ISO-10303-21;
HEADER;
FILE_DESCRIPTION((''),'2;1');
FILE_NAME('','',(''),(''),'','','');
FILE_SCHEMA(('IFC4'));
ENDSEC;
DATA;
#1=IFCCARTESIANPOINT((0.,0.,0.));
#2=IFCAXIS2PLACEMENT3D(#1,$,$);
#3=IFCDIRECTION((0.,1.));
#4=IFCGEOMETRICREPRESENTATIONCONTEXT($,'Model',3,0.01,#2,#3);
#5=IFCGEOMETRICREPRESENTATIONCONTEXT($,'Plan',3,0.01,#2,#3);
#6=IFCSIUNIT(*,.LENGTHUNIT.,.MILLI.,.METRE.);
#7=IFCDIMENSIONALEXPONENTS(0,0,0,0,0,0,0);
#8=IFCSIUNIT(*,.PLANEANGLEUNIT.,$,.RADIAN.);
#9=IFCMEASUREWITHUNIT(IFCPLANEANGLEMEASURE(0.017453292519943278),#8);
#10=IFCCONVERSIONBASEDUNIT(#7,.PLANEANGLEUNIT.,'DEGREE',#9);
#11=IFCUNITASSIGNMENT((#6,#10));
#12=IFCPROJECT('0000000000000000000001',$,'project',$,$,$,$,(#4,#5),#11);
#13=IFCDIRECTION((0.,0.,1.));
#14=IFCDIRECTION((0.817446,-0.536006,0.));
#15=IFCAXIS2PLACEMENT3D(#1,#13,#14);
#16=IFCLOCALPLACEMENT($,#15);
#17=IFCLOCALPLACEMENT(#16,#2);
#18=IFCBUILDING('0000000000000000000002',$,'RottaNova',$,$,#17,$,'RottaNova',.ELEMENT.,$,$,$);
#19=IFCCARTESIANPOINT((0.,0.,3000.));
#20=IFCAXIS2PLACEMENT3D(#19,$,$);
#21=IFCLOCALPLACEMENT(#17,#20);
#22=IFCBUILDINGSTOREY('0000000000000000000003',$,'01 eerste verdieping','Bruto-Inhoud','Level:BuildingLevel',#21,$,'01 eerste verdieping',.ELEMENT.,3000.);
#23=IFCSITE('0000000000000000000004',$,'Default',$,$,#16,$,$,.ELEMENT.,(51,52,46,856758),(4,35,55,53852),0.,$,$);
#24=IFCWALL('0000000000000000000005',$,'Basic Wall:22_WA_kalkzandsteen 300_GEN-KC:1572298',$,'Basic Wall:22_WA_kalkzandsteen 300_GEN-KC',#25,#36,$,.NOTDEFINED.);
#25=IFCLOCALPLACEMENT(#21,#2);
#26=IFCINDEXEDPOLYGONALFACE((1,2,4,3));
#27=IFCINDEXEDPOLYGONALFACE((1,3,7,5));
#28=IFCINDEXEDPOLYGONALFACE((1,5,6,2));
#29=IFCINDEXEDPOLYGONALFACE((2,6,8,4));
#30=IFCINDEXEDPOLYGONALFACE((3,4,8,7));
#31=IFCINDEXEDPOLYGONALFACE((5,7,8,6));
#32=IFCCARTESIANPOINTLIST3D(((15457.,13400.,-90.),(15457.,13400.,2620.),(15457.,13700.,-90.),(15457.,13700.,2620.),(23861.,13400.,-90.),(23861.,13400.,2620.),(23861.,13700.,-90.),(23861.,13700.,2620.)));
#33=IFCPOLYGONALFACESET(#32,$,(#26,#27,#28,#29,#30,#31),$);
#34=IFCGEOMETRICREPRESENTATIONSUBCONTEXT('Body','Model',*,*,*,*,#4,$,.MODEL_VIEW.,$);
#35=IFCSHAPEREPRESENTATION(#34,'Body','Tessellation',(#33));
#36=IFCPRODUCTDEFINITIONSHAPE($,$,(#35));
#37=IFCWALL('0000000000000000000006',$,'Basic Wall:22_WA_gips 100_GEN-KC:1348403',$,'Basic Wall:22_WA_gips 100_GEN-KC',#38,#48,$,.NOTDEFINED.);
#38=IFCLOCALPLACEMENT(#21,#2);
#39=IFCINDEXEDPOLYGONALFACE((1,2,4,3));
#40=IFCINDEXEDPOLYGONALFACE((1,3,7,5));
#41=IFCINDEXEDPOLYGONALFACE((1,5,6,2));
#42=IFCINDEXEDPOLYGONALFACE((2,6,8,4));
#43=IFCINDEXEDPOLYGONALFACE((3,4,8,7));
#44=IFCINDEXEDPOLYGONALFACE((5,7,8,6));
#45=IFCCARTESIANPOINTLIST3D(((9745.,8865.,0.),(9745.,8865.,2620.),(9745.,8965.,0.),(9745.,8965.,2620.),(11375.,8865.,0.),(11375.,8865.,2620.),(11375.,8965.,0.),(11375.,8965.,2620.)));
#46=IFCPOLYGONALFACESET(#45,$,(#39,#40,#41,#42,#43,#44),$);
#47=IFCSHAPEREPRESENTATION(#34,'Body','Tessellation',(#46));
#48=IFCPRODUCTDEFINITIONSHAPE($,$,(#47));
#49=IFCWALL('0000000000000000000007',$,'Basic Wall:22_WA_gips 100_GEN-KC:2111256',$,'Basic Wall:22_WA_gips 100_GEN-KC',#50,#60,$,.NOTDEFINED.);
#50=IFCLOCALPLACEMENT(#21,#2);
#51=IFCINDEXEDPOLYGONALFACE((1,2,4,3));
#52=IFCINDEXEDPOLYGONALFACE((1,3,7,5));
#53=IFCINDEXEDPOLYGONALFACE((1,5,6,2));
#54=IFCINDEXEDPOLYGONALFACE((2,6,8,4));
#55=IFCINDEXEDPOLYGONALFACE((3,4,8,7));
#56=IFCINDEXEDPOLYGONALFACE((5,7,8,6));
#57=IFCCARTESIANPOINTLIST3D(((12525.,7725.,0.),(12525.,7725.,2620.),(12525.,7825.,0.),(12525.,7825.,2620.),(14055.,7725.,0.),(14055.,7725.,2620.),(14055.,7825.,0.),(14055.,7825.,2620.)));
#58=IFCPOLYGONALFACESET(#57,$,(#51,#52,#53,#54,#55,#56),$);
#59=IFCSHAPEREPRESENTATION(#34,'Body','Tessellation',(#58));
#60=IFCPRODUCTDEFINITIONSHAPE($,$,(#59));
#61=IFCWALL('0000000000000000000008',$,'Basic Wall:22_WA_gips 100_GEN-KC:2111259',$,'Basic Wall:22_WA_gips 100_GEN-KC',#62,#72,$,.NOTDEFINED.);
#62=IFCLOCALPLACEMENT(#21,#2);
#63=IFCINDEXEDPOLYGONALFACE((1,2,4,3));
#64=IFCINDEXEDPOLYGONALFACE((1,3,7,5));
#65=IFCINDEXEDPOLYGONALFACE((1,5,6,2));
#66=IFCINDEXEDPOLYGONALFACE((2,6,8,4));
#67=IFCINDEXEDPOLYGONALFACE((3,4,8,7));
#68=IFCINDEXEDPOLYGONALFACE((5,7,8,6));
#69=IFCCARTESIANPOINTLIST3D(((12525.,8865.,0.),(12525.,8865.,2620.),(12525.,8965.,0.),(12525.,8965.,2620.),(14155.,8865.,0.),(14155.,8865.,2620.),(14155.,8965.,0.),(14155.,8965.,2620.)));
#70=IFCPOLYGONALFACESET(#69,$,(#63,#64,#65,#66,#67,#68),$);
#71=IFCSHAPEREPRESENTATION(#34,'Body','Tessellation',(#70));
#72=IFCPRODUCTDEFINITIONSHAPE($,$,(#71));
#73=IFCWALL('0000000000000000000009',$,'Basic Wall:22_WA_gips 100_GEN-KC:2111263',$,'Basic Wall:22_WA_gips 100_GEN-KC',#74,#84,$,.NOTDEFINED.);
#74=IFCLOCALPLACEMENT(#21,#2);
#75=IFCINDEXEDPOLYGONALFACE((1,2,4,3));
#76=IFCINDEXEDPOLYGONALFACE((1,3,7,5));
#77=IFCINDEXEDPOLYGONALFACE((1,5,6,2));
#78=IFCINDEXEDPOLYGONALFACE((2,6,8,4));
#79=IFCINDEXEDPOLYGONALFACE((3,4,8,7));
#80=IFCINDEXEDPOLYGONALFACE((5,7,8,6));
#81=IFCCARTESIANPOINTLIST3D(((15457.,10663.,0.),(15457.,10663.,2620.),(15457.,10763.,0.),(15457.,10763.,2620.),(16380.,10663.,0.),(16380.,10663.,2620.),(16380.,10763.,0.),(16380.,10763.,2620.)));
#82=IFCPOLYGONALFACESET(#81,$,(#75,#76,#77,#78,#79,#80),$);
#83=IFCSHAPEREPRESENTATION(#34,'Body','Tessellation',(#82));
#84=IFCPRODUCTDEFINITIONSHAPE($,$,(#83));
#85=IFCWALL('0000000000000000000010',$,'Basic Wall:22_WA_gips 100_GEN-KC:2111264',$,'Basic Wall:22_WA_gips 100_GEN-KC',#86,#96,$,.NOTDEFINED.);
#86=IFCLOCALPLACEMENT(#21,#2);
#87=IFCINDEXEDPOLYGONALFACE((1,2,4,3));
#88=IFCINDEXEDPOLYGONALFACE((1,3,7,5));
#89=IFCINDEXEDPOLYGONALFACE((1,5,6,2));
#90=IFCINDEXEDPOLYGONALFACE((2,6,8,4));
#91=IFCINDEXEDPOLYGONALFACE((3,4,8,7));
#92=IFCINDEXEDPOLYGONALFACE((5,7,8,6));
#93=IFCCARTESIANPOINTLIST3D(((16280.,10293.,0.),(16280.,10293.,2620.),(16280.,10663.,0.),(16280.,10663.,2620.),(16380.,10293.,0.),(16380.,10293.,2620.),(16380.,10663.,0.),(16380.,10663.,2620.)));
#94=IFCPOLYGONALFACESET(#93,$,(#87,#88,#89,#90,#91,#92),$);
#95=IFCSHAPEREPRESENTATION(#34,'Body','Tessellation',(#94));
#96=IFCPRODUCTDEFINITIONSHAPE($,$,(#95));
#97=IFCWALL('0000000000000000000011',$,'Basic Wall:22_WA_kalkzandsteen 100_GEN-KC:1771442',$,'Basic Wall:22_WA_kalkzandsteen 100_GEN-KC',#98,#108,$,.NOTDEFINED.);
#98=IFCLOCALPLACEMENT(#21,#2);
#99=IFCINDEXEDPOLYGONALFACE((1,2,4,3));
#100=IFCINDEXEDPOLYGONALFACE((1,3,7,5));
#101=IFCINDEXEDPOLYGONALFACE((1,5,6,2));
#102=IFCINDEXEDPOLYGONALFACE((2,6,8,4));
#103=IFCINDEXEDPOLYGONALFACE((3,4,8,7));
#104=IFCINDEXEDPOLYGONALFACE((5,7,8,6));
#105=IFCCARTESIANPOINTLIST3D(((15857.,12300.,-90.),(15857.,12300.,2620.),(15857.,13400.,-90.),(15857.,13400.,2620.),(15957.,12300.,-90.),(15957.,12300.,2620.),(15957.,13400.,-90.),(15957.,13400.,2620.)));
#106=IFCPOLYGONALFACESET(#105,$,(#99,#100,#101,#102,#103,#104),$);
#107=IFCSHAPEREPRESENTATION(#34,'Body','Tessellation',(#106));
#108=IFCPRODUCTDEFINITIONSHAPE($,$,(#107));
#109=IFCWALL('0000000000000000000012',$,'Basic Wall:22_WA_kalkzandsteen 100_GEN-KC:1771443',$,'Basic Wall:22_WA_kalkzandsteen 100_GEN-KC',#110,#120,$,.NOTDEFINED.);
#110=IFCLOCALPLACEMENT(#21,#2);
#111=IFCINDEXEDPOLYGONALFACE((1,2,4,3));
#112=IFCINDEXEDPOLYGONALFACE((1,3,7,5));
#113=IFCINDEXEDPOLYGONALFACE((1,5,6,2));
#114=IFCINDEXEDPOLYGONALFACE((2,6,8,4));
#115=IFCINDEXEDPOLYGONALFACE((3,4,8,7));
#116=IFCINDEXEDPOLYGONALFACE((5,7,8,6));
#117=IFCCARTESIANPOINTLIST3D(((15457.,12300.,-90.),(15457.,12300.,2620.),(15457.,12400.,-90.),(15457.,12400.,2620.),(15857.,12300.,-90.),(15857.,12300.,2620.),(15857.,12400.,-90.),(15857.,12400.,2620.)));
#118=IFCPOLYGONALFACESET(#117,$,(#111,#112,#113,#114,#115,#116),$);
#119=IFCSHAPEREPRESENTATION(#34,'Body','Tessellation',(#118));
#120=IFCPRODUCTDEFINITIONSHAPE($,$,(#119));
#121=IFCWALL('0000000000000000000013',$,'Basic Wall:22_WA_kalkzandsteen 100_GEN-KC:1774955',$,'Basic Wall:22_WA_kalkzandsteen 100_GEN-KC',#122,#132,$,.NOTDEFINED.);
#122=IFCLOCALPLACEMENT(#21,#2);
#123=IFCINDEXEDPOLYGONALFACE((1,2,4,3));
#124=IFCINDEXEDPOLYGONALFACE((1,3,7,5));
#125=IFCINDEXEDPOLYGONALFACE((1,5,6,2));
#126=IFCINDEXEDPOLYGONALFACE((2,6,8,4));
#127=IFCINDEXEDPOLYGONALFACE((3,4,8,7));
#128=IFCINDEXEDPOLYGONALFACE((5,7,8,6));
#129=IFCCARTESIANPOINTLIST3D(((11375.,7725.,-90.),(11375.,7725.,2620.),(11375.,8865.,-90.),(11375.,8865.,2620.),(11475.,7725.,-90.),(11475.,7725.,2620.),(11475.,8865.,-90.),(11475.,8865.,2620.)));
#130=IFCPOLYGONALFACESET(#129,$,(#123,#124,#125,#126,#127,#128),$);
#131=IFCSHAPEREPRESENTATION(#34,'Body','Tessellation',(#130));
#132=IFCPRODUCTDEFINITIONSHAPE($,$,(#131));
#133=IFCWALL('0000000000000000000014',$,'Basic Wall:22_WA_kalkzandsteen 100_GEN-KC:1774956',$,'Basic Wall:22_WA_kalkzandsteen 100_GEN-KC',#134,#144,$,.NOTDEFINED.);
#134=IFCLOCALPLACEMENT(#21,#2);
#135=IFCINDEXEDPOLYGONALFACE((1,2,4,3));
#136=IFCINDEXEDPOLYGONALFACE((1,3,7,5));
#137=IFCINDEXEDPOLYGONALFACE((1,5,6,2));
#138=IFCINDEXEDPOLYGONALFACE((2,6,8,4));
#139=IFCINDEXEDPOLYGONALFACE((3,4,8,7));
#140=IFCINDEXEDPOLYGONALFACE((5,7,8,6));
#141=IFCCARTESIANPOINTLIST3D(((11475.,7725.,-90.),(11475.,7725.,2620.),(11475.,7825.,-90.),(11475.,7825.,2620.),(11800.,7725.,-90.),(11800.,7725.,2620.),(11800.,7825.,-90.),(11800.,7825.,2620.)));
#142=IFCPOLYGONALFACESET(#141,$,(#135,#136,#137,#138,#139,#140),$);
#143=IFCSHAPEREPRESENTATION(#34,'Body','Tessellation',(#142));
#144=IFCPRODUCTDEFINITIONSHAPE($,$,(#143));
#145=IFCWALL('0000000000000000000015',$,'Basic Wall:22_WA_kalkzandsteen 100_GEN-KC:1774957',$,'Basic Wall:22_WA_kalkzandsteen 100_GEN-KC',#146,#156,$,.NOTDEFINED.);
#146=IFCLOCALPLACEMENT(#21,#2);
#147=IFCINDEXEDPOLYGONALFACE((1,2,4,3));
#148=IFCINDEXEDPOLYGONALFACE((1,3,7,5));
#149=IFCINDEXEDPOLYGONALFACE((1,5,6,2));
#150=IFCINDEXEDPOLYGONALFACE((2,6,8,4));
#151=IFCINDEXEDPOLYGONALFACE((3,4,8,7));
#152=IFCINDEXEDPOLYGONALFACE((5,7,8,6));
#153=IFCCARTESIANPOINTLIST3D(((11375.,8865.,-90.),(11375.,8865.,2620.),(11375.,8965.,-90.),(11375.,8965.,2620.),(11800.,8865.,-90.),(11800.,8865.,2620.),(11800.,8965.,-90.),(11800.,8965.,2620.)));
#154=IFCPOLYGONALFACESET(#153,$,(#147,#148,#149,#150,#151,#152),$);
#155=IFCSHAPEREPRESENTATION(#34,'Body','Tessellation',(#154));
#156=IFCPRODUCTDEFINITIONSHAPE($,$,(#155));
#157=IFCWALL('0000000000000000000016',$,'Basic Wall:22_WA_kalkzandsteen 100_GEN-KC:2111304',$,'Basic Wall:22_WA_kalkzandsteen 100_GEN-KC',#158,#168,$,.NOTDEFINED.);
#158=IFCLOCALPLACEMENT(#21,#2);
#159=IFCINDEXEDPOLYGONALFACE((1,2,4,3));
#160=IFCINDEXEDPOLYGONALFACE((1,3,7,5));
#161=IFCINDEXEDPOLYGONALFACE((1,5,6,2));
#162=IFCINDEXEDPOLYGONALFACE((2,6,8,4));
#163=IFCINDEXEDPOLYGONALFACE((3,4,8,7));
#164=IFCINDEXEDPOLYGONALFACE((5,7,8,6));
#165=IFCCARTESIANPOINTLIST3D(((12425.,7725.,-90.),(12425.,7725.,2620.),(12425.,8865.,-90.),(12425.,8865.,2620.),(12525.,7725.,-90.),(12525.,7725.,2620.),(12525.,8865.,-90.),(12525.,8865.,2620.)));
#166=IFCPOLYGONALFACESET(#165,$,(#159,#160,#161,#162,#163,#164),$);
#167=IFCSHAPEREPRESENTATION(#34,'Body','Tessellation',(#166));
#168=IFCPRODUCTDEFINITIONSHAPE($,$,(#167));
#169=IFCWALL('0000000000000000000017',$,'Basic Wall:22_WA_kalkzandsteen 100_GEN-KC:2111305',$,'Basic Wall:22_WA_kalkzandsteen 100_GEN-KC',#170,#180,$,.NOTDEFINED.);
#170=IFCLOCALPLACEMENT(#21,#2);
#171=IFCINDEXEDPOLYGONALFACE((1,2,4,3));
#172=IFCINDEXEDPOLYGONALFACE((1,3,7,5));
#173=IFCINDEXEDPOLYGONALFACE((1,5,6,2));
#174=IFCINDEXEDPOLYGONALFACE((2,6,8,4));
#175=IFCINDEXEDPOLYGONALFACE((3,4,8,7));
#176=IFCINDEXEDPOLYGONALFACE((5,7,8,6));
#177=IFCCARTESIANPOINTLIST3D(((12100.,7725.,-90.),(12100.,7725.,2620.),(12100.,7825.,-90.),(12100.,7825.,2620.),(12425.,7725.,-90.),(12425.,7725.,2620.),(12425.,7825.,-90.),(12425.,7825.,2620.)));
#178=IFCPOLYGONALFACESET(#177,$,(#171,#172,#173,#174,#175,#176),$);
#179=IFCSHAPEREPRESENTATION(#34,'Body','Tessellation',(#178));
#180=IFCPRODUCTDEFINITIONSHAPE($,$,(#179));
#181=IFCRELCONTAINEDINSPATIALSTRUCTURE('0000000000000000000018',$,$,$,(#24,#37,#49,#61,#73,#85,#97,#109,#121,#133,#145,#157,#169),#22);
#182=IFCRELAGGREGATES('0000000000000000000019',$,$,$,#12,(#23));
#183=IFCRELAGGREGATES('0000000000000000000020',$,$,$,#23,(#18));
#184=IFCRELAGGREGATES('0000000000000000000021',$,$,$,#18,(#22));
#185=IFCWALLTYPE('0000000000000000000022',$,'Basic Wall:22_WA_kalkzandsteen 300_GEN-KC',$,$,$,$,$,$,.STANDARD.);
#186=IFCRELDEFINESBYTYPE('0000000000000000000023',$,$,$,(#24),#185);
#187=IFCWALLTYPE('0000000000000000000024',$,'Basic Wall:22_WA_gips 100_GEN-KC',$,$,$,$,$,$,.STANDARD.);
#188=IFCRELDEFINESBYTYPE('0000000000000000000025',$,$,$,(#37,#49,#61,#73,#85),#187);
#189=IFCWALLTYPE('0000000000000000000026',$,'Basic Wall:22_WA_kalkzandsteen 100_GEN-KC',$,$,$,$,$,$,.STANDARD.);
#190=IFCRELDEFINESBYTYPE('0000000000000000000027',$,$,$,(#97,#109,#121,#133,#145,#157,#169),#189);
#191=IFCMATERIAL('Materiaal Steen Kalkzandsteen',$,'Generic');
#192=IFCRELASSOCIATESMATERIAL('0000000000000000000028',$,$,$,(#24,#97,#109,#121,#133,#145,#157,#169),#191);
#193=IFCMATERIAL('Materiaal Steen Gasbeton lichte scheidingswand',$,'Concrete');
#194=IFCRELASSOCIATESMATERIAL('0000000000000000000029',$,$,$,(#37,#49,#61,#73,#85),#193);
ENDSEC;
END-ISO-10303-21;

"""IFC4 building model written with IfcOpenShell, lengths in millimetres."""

from ifc_helpers import new_model, entity, si_unit, converted_unit, direction, frame, origin, place, context, subcontext, project, spatial, indexed_curve, outline, extrude, material, type_object, element, save


model = new_model("IFC4")

# Units and contexts
model_context = context("Model", 3, precision=0.01, world=origin(), true_north=direction((0.0, 1.0)))
plan_context = context("Plan", 3, precision=0.01, world=origin(), true_north=direction((0.0, 1.0)))
body_context = subcontext(model_context, "Body", "Model", "MODEL_VIEW")
ifc_project = project(units=[si_unit("LENGTHUNIT", "METRE", prefix="MILLI"), converted_unit("PLANEANGLEUNIT", "DEGREE", entity("IfcPlaneAngleMeasure", 0.017453292519943278), si_unit("PLANEANGLEUNIT", "RADIAN"), dimensions=[0, 0, 0, 0, 0, 0, 0])], contexts=[model_context, plan_context])

# Site, building, storey
site_placement = place(None, frame((0.0, 0.0, 0.0), z_axis=(0.0, 0.0, 1.0), x_axis=(0.817446, -0.536006, 0.0)))
site = spatial("IfcSite", under=ifc_project, at=site_placement, Name="Default", CompositionType="ELEMENT", RefLatitude=(51, 52, 46, 856758), RefLongitude=(4, 35, 55, 53852), RefElevation=0.0)
building_placement = place(site_placement, origin())
building = spatial("IfcBuilding", under=site, at=building_placement, Name="RottaNova", LongName="RottaNova", CompositionType="ELEMENT")
storey_placement = place(building_placement, frame((0.0, 0.0, 3000.0)))
storey = spatial("IfcBuildingStorey", under=building, at=storey_placement, Name="01 eerste verdieping", Description="Bruto-Inhoud", ObjectType="Level:BuildingLevel", LongName="01 eerste verdieping", CompositionType="ELEMENT", Elevation=3000.0)

# Walls
ifc_material_1 = material(Name="Materiaal Steen Kalkzandsteen", Category="Generic")
wall_type_1 = type_object("IfcWallType", Name="Basic Wall:22_WA_kalkzandsteen 300_GEN-KC", PredefinedType="STANDARD")
wall_1_placement = place(storey_placement, frame((15457.0, 13550.0, -90.0)))
element("IfcWall", 1, at=wall_1_placement, inside=storey, type_object=wall_type_1, material=ifc_material_1, Name="Basic Wall:22_WA_kalkzandsteen 300_GEN-KC:1572298", ObjectType="Basic Wall:22_WA_kalkzandsteen 300_GEN-KC", PredefinedType="NOTDEFINED", context=body_context, shape_type="SweptSolid", body=[
    extrude(outline(indexed_curve([(8404.0, 150.0), (0.0, 150.0), (0.0, -150.0), (8404.0, -150.0), (8404.0, 150.0)], self_intersect=False)), origin(), (0.0, 0.0, 1.0), 2710.0),
])
ifc_material_2 = material(Name="Materiaal Steen Gasbeton lichte scheidingswand", Category="Concrete")
wall_type_2 = type_object("IfcWallType", Name="Basic Wall:22_WA_gips 100_GEN-KC", PredefinedType="STANDARD")
wall_2_placement = place(storey_placement, frame((11375.0, 8915.0, 0.0), z_axis=(0.0, 0.0, 1.0), x_axis=(-1.0, 0.0, 0.0)))
element("IfcWall", 2, at=wall_2_placement, inside=storey, type_object=wall_type_2, material=ifc_material_2, Name="Basic Wall:22_WA_gips 100_GEN-KC:1348403", ObjectType="Basic Wall:22_WA_gips 100_GEN-KC", PredefinedType="NOTDEFINED", context=body_context, shape_type="SweptSolid", body=[
    extrude(outline(indexed_curve([(1630.0, 50.0), (0.0, 50.0), (0.0, -50.0), (1630.0, -50.0), (1630.0, 50.0)], self_intersect=False)), origin(), (0.0, 0.0, 1.0), 2620.0),
])
wall_3_placement = place(storey_placement, frame((14055.0, 7775.0, 0.0), z_axis=(0.0, 0.0, 1.0), x_axis=(-1.0, 0.0, 0.0)))
element("IfcWall", 3, at=wall_3_placement, inside=storey, type_object=wall_type_2, material=ifc_material_2, Name="Basic Wall:22_WA_gips 100_GEN-KC:2111256", ObjectType="Basic Wall:22_WA_gips 100_GEN-KC", PredefinedType="NOTDEFINED", context=body_context, shape_type="SweptSolid", body=[
    extrude(outline(indexed_curve([(1530.0, 50.0), (0.0, 50.0), (0.0, -50.0), (1530.0, -50.0), (1530.0, 50.0)], self_intersect=False)), origin(), (0.0, 0.0, 1.0), 2620.0),
])
wall_4_placement = place(storey_placement, frame((12525.0, 8915.0, 0.0)))
element("IfcWall", 4, at=wall_4_placement, inside=storey, type_object=wall_type_2, material=ifc_material_2, Name="Basic Wall:22_WA_gips 100_GEN-KC:2111259", ObjectType="Basic Wall:22_WA_gips 100_GEN-KC", PredefinedType="NOTDEFINED", context=body_context, shape_type="SweptSolid", body=[
    extrude(outline(indexed_curve([(1630.0, 50.0), (0.0, 50.0), (0.0, -50.0), (1630.0, -50.0), (1630.0, 50.0)], self_intersect=False)), origin(), (0.0, 0.0, 1.0), 2620.0),
])
wall_5_placement = place(storey_placement, frame((16380.0, 10713.0, 0.0), z_axis=(0.0, 0.0, 1.0), x_axis=(-1.0, 0.0, 0.0)))
element("IfcWall", 5, at=wall_5_placement, inside=storey, type_object=wall_type_2, material=ifc_material_2, Name="Basic Wall:22_WA_gips 100_GEN-KC:2111263", ObjectType="Basic Wall:22_WA_gips 100_GEN-KC", PredefinedType="NOTDEFINED", context=body_context, shape_type="SweptSolid", body=[
    extrude(outline(indexed_curve([(923.0, 50.0), (0.0, 50.0), (0.0, -50.0), (923.0, -50.0), (923.0, 50.0)], self_intersect=False)), origin(), (0.0, 0.0, 1.0), 2620.0),
])
wall_6_placement = place(storey_placement, frame((16330.0, 10663.0, 0.0), z_axis=(0.0, 0.0, 1.0), x_axis=(0.0, -1.0, 0.0)))
element("IfcWall", 6, at=wall_6_placement, inside=storey, type_object=wall_type_2, material=ifc_material_2, Name="Basic Wall:22_WA_gips 100_GEN-KC:2111264", ObjectType="Basic Wall:22_WA_gips 100_GEN-KC", PredefinedType="NOTDEFINED", context=body_context, shape_type="SweptSolid", body=[
    extrude(outline(indexed_curve([(370.0, 50.0), (0.0, 50.0), (0.0, -50.0), (370.0, -50.0), (370.0, 50.0)], self_intersect=False)), origin(), (0.0, 0.0, 1.0), 2620.0),
])
wall_type_3 = type_object("IfcWallType", Name="Basic Wall:22_WA_kalkzandsteen 100_GEN-KC", PredefinedType="STANDARD")
wall_7_placement = place(storey_placement, frame((15907.0, 13400.0, -90.0), z_axis=(0.0, 0.0, 1.0), x_axis=(0.0, -1.0, 0.0)))
element("IfcWall", 7, at=wall_7_placement, inside=storey, type_object=wall_type_3, material=ifc_material_1, Name="Basic Wall:22_WA_kalkzandsteen 100_GEN-KC:1771442", ObjectType="Basic Wall:22_WA_kalkzandsteen 100_GEN-KC", PredefinedType="NOTDEFINED", context=body_context, shape_type="SweptSolid", body=[
    extrude(outline(indexed_curve([(1100.0, 50.0), (0.0, 50.0), (0.0, -50.0), (1100.0, -50.0), (1100.0, 50.0)], self_intersect=False)), origin(), (0.0, 0.0, 1.0), 2710.0),
])
wall_8_placement = place(storey_placement, frame((15857.0, 12350.0, -90.0), z_axis=(0.0, 0.0, 1.0), x_axis=(-1.0, 0.0, 0.0)))
element("IfcWall", 8, at=wall_8_placement, inside=storey, type_object=wall_type_3, material=ifc_material_1, Name="Basic Wall:22_WA_kalkzandsteen 100_GEN-KC:1771443", ObjectType="Basic Wall:22_WA_kalkzandsteen 100_GEN-KC", PredefinedType="NOTDEFINED", context=body_context, shape_type="SweptSolid", body=[
    extrude(outline(indexed_curve([(400.0, 50.0), (0.0, 50.0), (0.0, -50.0), (400.0, -50.0), (400.0, 50.0)], self_intersect=False)), origin(), (0.0, 0.0, 1.0), 2710.0),
])
wall_9_placement = place(storey_placement, frame((11425.0, 8865.0, -90.0), z_axis=(0.0, 0.0, 1.0), x_axis=(0.0, -1.0, 0.0)))
element("IfcWall", 9, at=wall_9_placement, inside=storey, type_object=wall_type_3, material=ifc_material_1, Name="Basic Wall:22_WA_kalkzandsteen 100_GEN-KC:1774955", ObjectType="Basic Wall:22_WA_kalkzandsteen 100_GEN-KC", PredefinedType="NOTDEFINED", context=body_context, shape_type="SweptSolid", body=[
    extrude(outline(indexed_curve([(1140.0, 50.0), (0.0, 50.0), (0.0, -50.0), (1140.0, -50.0), (1140.0, 50.0)], self_intersect=False)), origin(), (0.0, 0.0, 1.0), 2710.0),
])
wall_10_placement = place(storey_placement, frame((11800.0, 7775.0, -90.0), z_axis=(0.0, 0.0, 1.0), x_axis=(-1.0, 0.0, 0.0)))
element("IfcWall", 10, at=wall_10_placement, inside=storey, type_object=wall_type_3, material=ifc_material_1, Name="Basic Wall:22_WA_kalkzandsteen 100_GEN-KC:1774956", ObjectType="Basic Wall:22_WA_kalkzandsteen 100_GEN-KC", PredefinedType="NOTDEFINED", context=body_context, shape_type="SweptSolid", body=[
    extrude(outline(indexed_curve([(325.0, 50.0), (0.0, 50.0), (0.0, -50.0), (325.0, -50.0), (325.0, 50.0)], self_intersect=False)), origin(), (0.0, 0.0, 1.0), 2710.0),
])
wall_11_placement = place(storey_placement, frame((11800.0, 8915.0, -90.0), z_axis=(0.0, 0.0, 1.0), x_axis=(-1.0, 0.0, 0.0)))
element("IfcWall", 11, at=wall_11_placement, inside=storey, type_object=wall_type_3, material=ifc_material_1, Name="Basic Wall:22_WA_kalkzandsteen 100_GEN-KC:1774957", ObjectType="Basic Wall:22_WA_kalkzandsteen 100_GEN-KC", PredefinedType="NOTDEFINED", context=body_context, shape_type="SweptSolid", body=[
    extrude(outline(indexed_curve([(425.0, 50.0), (0.0, 50.0), (0.0, -50.0), (425.0, -50.0), (425.0, 50.0)], self_intersect=False)), origin(), (0.0, 0.0, 1.0), 2710.0),
])
wall_12_placement = place(storey_placement, frame((12475.0, 8865.0, -90.0), z_axis=(0.0, 0.0, 1.0), x_axis=(0.0, -1.0, 0.0)))
element("IfcWall", 12, at=wall_12_placement, inside=storey, type_object=wall_type_3, material=ifc_material_1, Name="Basic Wall:22_WA_kalkzandsteen 100_GEN-KC:2111304", ObjectType="Basic Wall:22_WA_kalkzandsteen 100_GEN-KC", PredefinedType="NOTDEFINED", context=body_context, shape_type="SweptSolid", body=[
    extrude(outline(indexed_curve([(1140.0, 50.0), (0.0, 50.0), (0.0, -50.0), (1140.0, -50.0), (1140.0, 50.0)], self_intersect=False)), origin(), (0.0, 0.0, 1.0), 2710.0),
])
wall_13_placement = place(storey_placement, frame((12100.0, 7775.0, -90.0)))
element("IfcWall", 13, at=wall_13_placement, inside=storey, type_object=wall_type_3, material=ifc_material_1, Name="Basic Wall:22_WA_kalkzandsteen 100_GEN-KC:2111305", ObjectType="Basic Wall:22_WA_kalkzandsteen 100_GEN-KC", PredefinedType="NOTDEFINED", context=body_context, shape_type="SweptSolid", body=[
    extrude(outline(indexed_curve([(325.0, 50.0), (0.0, 50.0), (0.0, -50.0), (325.0, -50.0), (325.0, 50.0)], self_intersect=False)), origin(), (0.0, 0.0, 1.0), 2710.0),
])

save(model, "model.ifc")
